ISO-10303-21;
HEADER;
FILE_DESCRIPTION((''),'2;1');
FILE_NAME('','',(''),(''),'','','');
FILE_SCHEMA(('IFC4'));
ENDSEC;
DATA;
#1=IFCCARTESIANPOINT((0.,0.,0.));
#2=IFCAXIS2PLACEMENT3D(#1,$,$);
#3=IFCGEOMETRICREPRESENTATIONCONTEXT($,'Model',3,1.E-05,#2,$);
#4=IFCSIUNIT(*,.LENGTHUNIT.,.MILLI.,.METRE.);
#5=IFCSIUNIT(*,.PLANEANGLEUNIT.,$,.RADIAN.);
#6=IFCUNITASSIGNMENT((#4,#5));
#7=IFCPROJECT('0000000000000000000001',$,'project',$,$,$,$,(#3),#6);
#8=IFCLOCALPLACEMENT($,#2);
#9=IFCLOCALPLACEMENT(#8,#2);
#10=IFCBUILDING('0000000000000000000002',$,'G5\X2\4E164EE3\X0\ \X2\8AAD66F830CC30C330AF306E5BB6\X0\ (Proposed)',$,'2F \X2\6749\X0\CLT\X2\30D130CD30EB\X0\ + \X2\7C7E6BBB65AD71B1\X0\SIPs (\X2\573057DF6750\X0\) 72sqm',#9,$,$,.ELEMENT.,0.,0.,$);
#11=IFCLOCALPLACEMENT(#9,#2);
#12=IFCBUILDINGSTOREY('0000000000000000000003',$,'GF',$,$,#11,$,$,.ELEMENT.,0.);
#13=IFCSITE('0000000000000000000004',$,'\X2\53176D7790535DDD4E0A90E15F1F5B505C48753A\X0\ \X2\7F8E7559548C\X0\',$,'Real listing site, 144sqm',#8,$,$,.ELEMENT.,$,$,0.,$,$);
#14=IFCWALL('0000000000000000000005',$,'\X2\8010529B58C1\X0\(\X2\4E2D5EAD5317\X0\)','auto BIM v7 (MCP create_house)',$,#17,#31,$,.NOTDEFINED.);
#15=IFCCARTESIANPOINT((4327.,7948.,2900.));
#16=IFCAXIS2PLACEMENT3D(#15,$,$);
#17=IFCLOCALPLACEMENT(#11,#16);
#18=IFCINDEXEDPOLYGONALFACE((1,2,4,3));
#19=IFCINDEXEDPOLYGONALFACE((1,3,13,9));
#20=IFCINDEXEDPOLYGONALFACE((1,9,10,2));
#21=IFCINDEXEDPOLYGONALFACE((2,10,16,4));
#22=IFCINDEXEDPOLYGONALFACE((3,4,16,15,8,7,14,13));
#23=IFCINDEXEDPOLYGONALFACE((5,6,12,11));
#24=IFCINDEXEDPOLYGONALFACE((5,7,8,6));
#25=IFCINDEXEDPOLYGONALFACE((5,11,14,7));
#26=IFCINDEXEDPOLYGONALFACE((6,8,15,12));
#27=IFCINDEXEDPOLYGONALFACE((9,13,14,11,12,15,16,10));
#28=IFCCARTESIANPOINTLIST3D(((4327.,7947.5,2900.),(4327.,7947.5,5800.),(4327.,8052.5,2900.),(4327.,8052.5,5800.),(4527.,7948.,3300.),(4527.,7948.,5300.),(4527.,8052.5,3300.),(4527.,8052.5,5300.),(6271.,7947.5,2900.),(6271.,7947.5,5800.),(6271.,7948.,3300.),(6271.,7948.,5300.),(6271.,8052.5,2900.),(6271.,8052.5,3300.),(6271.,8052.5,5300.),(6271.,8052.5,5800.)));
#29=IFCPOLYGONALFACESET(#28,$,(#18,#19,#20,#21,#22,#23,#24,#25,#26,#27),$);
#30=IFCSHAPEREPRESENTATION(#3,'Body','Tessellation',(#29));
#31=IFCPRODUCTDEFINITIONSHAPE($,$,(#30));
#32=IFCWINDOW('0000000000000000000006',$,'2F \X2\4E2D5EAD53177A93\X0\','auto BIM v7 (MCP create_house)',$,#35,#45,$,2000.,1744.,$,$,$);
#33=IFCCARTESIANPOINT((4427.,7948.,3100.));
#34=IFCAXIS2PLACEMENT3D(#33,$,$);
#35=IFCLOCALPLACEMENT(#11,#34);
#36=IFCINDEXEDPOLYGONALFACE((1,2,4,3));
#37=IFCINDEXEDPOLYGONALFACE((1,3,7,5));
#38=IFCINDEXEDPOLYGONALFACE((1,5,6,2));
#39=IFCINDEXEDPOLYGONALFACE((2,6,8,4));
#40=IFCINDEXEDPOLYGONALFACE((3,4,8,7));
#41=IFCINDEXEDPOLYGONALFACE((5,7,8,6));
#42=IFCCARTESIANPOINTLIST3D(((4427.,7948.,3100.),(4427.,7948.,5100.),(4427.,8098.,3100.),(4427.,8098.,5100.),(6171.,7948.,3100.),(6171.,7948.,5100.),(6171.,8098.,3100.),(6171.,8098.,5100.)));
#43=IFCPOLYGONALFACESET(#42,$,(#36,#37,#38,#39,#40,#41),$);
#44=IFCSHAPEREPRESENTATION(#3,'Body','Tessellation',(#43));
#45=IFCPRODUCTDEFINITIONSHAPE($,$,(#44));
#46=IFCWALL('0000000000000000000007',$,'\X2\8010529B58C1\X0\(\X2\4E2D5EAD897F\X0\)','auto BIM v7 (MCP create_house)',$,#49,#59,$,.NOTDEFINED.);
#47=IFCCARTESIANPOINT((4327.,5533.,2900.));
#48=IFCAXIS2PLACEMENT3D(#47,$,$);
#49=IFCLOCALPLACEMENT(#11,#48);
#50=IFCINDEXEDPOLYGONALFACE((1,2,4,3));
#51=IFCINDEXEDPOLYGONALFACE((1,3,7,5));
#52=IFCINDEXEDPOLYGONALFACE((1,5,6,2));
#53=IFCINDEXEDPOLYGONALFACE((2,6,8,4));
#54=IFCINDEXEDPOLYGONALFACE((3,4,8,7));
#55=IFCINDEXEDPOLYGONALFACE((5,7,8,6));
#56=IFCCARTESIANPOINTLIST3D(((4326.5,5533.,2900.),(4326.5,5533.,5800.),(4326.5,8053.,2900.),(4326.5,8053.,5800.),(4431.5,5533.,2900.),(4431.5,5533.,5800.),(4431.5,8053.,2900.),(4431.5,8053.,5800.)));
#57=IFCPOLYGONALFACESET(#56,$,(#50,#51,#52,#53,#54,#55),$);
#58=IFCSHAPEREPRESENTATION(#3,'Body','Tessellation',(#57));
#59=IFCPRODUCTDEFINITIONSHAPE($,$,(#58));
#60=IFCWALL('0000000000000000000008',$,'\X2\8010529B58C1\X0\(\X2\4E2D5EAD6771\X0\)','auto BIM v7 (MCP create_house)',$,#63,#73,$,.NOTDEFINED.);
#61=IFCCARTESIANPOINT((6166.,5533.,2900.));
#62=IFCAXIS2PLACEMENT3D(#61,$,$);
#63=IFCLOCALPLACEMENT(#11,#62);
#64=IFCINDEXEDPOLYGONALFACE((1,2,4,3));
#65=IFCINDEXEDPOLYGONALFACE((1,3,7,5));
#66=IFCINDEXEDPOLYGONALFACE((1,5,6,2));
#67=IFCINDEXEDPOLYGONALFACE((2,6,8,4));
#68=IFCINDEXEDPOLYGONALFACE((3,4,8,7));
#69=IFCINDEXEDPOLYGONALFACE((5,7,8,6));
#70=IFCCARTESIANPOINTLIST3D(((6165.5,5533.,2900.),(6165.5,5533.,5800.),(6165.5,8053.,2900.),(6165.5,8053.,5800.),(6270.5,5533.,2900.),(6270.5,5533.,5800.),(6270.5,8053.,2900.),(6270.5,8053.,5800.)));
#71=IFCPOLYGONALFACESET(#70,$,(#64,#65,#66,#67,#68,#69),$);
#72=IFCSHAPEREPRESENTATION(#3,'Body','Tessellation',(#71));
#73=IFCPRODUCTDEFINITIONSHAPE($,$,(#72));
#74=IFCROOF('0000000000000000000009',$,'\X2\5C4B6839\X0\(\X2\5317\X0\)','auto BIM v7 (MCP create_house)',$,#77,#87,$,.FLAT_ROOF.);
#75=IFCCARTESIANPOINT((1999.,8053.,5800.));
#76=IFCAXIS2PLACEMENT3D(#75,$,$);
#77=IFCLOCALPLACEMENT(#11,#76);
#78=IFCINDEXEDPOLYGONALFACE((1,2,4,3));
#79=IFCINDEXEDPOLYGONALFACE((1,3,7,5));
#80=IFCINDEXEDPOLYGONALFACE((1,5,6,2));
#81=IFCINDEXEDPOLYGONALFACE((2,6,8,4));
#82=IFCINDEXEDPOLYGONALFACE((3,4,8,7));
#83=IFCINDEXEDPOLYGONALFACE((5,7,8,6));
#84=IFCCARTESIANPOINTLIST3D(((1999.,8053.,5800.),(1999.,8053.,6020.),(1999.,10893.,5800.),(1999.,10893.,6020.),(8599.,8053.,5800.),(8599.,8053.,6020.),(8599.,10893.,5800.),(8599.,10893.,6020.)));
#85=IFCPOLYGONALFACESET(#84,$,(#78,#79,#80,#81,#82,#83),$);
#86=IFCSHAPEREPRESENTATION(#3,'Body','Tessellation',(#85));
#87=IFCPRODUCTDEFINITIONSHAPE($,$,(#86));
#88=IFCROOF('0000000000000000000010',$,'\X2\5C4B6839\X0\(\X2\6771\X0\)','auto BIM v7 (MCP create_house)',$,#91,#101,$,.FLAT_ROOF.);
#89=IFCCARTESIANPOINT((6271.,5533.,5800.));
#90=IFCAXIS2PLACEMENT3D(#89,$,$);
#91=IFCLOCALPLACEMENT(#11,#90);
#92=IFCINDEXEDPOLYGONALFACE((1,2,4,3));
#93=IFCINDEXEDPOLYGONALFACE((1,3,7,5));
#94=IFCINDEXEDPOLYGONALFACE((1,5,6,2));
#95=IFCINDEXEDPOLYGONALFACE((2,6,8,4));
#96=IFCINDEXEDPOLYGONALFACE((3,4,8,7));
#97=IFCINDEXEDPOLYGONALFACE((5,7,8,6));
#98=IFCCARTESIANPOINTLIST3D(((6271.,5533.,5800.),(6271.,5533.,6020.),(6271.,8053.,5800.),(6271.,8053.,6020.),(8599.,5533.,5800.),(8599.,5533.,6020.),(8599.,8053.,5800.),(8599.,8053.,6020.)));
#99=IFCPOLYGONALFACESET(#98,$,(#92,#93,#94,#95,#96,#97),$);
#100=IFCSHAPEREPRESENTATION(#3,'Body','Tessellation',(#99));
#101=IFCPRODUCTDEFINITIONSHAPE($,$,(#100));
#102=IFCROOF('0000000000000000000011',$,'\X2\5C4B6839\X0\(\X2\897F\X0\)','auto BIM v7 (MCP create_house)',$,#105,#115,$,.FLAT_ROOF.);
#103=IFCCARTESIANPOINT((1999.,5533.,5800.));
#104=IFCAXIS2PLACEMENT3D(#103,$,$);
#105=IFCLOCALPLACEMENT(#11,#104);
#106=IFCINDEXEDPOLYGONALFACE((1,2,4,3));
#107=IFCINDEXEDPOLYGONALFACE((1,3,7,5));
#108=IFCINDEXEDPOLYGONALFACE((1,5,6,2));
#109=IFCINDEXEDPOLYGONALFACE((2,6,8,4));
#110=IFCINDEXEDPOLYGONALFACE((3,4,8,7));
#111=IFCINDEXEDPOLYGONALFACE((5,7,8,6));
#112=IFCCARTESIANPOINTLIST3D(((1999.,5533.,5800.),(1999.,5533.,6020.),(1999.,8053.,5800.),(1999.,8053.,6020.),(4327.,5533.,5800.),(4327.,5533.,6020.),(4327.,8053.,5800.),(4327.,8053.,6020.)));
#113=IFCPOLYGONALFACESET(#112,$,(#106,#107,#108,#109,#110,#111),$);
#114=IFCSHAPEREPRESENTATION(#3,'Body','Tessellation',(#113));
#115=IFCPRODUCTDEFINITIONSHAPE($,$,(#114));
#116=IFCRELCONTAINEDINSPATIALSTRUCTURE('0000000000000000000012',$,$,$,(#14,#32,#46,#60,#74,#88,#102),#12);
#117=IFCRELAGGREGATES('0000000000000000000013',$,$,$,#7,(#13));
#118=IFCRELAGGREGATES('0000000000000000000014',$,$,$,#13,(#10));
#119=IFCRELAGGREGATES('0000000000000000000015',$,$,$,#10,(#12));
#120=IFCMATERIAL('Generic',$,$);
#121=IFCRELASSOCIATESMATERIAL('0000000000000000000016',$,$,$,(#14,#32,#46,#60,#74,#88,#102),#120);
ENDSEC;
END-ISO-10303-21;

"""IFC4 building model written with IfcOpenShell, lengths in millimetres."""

from ifc_helpers import new_model, si_unit, frame, frame_2d, origin, place, context, project, spatial, rectangle, extrude, material, element, fill, save


model = new_model("IFC4")

# Units and contexts
model_context = context("Model", 3, precision=1e-05, world=origin())
ifc_project = project(units=[si_unit("LENGTHUNIT", "METRE", prefix="MILLI"), si_unit("PLANEANGLEUNIT", "RADIAN")], contexts=[model_context])

# Site, building, storey
site_placement = place(None, origin())
site = spatial("IfcSite", under=ifc_project, at=site_placement, Name="北海道川上郡弟子屈町 美留和", ObjectType="Real listing site, 144sqm", CompositionType="ELEMENT", RefElevation=0.0)
building_placement = place(site_placement, origin())
building = spatial("IfcBuilding", under=site, at=building_placement, Name="G5世代 読書ヌックの家 (Proposed)", ObjectType="2F 杉CLTパネル + 籾殻断熱SIPs (地域材) 72sqm", CompositionType="ELEMENT", ElevationOfRefHeight=0.0, ElevationOfTerrain=0.0)
storey_placement = place(building_placement, origin())
storey = spatial("IfcBuildingStorey", under=building, at=storey_placement, Name="GF", CompositionType="ELEMENT", Elevation=0.0)

# Shared definitions
ifc_material = material(Name="Generic")

# Wall, opening, window
wall_1_placement = place(storey_placement, frame((4327.0, 7948.0, 2900.0)))
wall_1 = element("IfcWall", 1, at=wall_1_placement, inside=storey, material=ifc_material, Name="耐力壁(中庭北)", Description="auto BIM v7 (MCP create_house)", PredefinedType="NOTDEFINED", context=model_context, shape_type="SweptSolid", body=[
    extrude(rectangle(XDim=1944.0, YDim=105.0, at=frame_2d((972.0, 52.0))), frame((4327.0, 7948.0, 2900.0)), (0.0, 0.0, 1.0), 2900.0),
])
opening_1_placement = place(storey_placement, frame((4427.0, 7948.0, 3100.0)))
opening_1 = element("IfcOpeningElement", 2, at=opening_1_placement, cuts=wall_1, PredefinedType="NOTDEFINED", context=model_context, shape_type="SweptSolid", body=[
    extrude(rectangle(XDim=1744.0, YDim=150.0, at=frame_2d((872.0, 75.0))), frame((4427.0, 7948.0, 3100.0)), (0.0, 0.0, 1.0), 2000.0),
])
window_1_placement = place(storey_placement, frame((4427.0, 7948.0, 3100.0)))
window_1 = element("IfcWindow", 3, at=window_1_placement, inside=storey, material=ifc_material, Name="2F 中庭北窓", Description="auto BIM v7 (MCP create_house)", OverallHeight=2000.0, OverallWidth=1744.0, context=model_context, shape_type="SweptSolid", body=[
    extrude(rectangle(XDim=1744.0, YDim=150.0, at=frame_2d((872.0, 75.0))), frame((4427.0, 7948.0, 3100.0)), (0.0, 0.0, 1.0), 2000.0),
])
fill(opening_1, window_1)

# Walls
wall_2_placement = place(storey_placement, frame((4327.0, 5533.0, 2900.0)))
element("IfcWall", 4, at=wall_2_placement, inside=storey, material=ifc_material, Name="耐力壁(中庭西)", Description="auto BIM v7 (MCP create_house)", PredefinedType="NOTDEFINED", context=model_context, shape_type="SweptSolid", body=[
    extrude(rectangle(XDim=105.0, YDim=2520.0, at=frame_2d((52.0, 1260.0))), frame((4327.0, 5533.0, 2900.0)), (0.0, 0.0, 1.0), 2900.0),
])
wall_3_placement = place(storey_placement, frame((6166.0, 5533.0, 2900.0)))
element("IfcWall", 5, at=wall_3_placement, inside=storey, material=ifc_material, Name="耐力壁(中庭東)", Description="auto BIM v7 (MCP create_house)", PredefinedType="NOTDEFINED", context=model_context, shape_type="SweptSolid", body=[
    extrude(rectangle(XDim=105.0, YDim=2520.0, at=frame_2d((52.0, 1260.0))), frame((6166.0, 5533.0, 2900.0)), (0.0, 0.0, 1.0), 2900.0),
])

# Roofs
roof_1_placement = place(storey_placement, frame((1999.0, 8053.0, 5800.0)))
element("IfcRoof", 6, at=roof_1_placement, inside=storey, material=ifc_material, Name="屋根(北)", Description="auto BIM v7 (MCP create_house)", PredefinedType="FLAT_ROOF", context=model_context, shape_type="SweptSolid", body=[
    extrude(rectangle(XDim=6600.0, YDim=2840.0, at=frame_2d((3300.0, 1420.0))), frame((1999.0, 8053.0, 5800.0)), (0.0, 0.0, 1.0), 220.0),
])
roof_2_placement = place(storey_placement, frame((6271.0, 5533.0, 5800.0)))
element("IfcRoof", 7, at=roof_2_placement, inside=storey, material=ifc_material, Name="屋根(東)", Description="auto BIM v7 (MCP create_house)", PredefinedType="FLAT_ROOF", context=model_context, shape_type="SweptSolid", body=[
    extrude(rectangle(XDim=2328.0, YDim=2520.0, at=frame_2d((1164.0, 1260.0))), frame((6271.0, 5533.0, 5800.0)), (0.0, 0.0, 1.0), 220.0),
])
roof_3_placement = place(storey_placement, frame((1999.0, 5533.0, 5800.0)))
element("IfcRoof", 8, at=roof_3_placement, inside=storey, material=ifc_material, Name="屋根(西)", Description="auto BIM v7 (MCP create_house)", PredefinedType="FLAT_ROOF", context=model_context, shape_type="SweptSolid", body=[
    extrude(rectangle(XDim=2328.0, YDim=2520.0, at=frame_2d((1164.0, 1260.0))), frame((1999.0, 5533.0, 5800.0)), (0.0, 0.0, 1.0), 220.0),
])

save(model, "model.ifc")
